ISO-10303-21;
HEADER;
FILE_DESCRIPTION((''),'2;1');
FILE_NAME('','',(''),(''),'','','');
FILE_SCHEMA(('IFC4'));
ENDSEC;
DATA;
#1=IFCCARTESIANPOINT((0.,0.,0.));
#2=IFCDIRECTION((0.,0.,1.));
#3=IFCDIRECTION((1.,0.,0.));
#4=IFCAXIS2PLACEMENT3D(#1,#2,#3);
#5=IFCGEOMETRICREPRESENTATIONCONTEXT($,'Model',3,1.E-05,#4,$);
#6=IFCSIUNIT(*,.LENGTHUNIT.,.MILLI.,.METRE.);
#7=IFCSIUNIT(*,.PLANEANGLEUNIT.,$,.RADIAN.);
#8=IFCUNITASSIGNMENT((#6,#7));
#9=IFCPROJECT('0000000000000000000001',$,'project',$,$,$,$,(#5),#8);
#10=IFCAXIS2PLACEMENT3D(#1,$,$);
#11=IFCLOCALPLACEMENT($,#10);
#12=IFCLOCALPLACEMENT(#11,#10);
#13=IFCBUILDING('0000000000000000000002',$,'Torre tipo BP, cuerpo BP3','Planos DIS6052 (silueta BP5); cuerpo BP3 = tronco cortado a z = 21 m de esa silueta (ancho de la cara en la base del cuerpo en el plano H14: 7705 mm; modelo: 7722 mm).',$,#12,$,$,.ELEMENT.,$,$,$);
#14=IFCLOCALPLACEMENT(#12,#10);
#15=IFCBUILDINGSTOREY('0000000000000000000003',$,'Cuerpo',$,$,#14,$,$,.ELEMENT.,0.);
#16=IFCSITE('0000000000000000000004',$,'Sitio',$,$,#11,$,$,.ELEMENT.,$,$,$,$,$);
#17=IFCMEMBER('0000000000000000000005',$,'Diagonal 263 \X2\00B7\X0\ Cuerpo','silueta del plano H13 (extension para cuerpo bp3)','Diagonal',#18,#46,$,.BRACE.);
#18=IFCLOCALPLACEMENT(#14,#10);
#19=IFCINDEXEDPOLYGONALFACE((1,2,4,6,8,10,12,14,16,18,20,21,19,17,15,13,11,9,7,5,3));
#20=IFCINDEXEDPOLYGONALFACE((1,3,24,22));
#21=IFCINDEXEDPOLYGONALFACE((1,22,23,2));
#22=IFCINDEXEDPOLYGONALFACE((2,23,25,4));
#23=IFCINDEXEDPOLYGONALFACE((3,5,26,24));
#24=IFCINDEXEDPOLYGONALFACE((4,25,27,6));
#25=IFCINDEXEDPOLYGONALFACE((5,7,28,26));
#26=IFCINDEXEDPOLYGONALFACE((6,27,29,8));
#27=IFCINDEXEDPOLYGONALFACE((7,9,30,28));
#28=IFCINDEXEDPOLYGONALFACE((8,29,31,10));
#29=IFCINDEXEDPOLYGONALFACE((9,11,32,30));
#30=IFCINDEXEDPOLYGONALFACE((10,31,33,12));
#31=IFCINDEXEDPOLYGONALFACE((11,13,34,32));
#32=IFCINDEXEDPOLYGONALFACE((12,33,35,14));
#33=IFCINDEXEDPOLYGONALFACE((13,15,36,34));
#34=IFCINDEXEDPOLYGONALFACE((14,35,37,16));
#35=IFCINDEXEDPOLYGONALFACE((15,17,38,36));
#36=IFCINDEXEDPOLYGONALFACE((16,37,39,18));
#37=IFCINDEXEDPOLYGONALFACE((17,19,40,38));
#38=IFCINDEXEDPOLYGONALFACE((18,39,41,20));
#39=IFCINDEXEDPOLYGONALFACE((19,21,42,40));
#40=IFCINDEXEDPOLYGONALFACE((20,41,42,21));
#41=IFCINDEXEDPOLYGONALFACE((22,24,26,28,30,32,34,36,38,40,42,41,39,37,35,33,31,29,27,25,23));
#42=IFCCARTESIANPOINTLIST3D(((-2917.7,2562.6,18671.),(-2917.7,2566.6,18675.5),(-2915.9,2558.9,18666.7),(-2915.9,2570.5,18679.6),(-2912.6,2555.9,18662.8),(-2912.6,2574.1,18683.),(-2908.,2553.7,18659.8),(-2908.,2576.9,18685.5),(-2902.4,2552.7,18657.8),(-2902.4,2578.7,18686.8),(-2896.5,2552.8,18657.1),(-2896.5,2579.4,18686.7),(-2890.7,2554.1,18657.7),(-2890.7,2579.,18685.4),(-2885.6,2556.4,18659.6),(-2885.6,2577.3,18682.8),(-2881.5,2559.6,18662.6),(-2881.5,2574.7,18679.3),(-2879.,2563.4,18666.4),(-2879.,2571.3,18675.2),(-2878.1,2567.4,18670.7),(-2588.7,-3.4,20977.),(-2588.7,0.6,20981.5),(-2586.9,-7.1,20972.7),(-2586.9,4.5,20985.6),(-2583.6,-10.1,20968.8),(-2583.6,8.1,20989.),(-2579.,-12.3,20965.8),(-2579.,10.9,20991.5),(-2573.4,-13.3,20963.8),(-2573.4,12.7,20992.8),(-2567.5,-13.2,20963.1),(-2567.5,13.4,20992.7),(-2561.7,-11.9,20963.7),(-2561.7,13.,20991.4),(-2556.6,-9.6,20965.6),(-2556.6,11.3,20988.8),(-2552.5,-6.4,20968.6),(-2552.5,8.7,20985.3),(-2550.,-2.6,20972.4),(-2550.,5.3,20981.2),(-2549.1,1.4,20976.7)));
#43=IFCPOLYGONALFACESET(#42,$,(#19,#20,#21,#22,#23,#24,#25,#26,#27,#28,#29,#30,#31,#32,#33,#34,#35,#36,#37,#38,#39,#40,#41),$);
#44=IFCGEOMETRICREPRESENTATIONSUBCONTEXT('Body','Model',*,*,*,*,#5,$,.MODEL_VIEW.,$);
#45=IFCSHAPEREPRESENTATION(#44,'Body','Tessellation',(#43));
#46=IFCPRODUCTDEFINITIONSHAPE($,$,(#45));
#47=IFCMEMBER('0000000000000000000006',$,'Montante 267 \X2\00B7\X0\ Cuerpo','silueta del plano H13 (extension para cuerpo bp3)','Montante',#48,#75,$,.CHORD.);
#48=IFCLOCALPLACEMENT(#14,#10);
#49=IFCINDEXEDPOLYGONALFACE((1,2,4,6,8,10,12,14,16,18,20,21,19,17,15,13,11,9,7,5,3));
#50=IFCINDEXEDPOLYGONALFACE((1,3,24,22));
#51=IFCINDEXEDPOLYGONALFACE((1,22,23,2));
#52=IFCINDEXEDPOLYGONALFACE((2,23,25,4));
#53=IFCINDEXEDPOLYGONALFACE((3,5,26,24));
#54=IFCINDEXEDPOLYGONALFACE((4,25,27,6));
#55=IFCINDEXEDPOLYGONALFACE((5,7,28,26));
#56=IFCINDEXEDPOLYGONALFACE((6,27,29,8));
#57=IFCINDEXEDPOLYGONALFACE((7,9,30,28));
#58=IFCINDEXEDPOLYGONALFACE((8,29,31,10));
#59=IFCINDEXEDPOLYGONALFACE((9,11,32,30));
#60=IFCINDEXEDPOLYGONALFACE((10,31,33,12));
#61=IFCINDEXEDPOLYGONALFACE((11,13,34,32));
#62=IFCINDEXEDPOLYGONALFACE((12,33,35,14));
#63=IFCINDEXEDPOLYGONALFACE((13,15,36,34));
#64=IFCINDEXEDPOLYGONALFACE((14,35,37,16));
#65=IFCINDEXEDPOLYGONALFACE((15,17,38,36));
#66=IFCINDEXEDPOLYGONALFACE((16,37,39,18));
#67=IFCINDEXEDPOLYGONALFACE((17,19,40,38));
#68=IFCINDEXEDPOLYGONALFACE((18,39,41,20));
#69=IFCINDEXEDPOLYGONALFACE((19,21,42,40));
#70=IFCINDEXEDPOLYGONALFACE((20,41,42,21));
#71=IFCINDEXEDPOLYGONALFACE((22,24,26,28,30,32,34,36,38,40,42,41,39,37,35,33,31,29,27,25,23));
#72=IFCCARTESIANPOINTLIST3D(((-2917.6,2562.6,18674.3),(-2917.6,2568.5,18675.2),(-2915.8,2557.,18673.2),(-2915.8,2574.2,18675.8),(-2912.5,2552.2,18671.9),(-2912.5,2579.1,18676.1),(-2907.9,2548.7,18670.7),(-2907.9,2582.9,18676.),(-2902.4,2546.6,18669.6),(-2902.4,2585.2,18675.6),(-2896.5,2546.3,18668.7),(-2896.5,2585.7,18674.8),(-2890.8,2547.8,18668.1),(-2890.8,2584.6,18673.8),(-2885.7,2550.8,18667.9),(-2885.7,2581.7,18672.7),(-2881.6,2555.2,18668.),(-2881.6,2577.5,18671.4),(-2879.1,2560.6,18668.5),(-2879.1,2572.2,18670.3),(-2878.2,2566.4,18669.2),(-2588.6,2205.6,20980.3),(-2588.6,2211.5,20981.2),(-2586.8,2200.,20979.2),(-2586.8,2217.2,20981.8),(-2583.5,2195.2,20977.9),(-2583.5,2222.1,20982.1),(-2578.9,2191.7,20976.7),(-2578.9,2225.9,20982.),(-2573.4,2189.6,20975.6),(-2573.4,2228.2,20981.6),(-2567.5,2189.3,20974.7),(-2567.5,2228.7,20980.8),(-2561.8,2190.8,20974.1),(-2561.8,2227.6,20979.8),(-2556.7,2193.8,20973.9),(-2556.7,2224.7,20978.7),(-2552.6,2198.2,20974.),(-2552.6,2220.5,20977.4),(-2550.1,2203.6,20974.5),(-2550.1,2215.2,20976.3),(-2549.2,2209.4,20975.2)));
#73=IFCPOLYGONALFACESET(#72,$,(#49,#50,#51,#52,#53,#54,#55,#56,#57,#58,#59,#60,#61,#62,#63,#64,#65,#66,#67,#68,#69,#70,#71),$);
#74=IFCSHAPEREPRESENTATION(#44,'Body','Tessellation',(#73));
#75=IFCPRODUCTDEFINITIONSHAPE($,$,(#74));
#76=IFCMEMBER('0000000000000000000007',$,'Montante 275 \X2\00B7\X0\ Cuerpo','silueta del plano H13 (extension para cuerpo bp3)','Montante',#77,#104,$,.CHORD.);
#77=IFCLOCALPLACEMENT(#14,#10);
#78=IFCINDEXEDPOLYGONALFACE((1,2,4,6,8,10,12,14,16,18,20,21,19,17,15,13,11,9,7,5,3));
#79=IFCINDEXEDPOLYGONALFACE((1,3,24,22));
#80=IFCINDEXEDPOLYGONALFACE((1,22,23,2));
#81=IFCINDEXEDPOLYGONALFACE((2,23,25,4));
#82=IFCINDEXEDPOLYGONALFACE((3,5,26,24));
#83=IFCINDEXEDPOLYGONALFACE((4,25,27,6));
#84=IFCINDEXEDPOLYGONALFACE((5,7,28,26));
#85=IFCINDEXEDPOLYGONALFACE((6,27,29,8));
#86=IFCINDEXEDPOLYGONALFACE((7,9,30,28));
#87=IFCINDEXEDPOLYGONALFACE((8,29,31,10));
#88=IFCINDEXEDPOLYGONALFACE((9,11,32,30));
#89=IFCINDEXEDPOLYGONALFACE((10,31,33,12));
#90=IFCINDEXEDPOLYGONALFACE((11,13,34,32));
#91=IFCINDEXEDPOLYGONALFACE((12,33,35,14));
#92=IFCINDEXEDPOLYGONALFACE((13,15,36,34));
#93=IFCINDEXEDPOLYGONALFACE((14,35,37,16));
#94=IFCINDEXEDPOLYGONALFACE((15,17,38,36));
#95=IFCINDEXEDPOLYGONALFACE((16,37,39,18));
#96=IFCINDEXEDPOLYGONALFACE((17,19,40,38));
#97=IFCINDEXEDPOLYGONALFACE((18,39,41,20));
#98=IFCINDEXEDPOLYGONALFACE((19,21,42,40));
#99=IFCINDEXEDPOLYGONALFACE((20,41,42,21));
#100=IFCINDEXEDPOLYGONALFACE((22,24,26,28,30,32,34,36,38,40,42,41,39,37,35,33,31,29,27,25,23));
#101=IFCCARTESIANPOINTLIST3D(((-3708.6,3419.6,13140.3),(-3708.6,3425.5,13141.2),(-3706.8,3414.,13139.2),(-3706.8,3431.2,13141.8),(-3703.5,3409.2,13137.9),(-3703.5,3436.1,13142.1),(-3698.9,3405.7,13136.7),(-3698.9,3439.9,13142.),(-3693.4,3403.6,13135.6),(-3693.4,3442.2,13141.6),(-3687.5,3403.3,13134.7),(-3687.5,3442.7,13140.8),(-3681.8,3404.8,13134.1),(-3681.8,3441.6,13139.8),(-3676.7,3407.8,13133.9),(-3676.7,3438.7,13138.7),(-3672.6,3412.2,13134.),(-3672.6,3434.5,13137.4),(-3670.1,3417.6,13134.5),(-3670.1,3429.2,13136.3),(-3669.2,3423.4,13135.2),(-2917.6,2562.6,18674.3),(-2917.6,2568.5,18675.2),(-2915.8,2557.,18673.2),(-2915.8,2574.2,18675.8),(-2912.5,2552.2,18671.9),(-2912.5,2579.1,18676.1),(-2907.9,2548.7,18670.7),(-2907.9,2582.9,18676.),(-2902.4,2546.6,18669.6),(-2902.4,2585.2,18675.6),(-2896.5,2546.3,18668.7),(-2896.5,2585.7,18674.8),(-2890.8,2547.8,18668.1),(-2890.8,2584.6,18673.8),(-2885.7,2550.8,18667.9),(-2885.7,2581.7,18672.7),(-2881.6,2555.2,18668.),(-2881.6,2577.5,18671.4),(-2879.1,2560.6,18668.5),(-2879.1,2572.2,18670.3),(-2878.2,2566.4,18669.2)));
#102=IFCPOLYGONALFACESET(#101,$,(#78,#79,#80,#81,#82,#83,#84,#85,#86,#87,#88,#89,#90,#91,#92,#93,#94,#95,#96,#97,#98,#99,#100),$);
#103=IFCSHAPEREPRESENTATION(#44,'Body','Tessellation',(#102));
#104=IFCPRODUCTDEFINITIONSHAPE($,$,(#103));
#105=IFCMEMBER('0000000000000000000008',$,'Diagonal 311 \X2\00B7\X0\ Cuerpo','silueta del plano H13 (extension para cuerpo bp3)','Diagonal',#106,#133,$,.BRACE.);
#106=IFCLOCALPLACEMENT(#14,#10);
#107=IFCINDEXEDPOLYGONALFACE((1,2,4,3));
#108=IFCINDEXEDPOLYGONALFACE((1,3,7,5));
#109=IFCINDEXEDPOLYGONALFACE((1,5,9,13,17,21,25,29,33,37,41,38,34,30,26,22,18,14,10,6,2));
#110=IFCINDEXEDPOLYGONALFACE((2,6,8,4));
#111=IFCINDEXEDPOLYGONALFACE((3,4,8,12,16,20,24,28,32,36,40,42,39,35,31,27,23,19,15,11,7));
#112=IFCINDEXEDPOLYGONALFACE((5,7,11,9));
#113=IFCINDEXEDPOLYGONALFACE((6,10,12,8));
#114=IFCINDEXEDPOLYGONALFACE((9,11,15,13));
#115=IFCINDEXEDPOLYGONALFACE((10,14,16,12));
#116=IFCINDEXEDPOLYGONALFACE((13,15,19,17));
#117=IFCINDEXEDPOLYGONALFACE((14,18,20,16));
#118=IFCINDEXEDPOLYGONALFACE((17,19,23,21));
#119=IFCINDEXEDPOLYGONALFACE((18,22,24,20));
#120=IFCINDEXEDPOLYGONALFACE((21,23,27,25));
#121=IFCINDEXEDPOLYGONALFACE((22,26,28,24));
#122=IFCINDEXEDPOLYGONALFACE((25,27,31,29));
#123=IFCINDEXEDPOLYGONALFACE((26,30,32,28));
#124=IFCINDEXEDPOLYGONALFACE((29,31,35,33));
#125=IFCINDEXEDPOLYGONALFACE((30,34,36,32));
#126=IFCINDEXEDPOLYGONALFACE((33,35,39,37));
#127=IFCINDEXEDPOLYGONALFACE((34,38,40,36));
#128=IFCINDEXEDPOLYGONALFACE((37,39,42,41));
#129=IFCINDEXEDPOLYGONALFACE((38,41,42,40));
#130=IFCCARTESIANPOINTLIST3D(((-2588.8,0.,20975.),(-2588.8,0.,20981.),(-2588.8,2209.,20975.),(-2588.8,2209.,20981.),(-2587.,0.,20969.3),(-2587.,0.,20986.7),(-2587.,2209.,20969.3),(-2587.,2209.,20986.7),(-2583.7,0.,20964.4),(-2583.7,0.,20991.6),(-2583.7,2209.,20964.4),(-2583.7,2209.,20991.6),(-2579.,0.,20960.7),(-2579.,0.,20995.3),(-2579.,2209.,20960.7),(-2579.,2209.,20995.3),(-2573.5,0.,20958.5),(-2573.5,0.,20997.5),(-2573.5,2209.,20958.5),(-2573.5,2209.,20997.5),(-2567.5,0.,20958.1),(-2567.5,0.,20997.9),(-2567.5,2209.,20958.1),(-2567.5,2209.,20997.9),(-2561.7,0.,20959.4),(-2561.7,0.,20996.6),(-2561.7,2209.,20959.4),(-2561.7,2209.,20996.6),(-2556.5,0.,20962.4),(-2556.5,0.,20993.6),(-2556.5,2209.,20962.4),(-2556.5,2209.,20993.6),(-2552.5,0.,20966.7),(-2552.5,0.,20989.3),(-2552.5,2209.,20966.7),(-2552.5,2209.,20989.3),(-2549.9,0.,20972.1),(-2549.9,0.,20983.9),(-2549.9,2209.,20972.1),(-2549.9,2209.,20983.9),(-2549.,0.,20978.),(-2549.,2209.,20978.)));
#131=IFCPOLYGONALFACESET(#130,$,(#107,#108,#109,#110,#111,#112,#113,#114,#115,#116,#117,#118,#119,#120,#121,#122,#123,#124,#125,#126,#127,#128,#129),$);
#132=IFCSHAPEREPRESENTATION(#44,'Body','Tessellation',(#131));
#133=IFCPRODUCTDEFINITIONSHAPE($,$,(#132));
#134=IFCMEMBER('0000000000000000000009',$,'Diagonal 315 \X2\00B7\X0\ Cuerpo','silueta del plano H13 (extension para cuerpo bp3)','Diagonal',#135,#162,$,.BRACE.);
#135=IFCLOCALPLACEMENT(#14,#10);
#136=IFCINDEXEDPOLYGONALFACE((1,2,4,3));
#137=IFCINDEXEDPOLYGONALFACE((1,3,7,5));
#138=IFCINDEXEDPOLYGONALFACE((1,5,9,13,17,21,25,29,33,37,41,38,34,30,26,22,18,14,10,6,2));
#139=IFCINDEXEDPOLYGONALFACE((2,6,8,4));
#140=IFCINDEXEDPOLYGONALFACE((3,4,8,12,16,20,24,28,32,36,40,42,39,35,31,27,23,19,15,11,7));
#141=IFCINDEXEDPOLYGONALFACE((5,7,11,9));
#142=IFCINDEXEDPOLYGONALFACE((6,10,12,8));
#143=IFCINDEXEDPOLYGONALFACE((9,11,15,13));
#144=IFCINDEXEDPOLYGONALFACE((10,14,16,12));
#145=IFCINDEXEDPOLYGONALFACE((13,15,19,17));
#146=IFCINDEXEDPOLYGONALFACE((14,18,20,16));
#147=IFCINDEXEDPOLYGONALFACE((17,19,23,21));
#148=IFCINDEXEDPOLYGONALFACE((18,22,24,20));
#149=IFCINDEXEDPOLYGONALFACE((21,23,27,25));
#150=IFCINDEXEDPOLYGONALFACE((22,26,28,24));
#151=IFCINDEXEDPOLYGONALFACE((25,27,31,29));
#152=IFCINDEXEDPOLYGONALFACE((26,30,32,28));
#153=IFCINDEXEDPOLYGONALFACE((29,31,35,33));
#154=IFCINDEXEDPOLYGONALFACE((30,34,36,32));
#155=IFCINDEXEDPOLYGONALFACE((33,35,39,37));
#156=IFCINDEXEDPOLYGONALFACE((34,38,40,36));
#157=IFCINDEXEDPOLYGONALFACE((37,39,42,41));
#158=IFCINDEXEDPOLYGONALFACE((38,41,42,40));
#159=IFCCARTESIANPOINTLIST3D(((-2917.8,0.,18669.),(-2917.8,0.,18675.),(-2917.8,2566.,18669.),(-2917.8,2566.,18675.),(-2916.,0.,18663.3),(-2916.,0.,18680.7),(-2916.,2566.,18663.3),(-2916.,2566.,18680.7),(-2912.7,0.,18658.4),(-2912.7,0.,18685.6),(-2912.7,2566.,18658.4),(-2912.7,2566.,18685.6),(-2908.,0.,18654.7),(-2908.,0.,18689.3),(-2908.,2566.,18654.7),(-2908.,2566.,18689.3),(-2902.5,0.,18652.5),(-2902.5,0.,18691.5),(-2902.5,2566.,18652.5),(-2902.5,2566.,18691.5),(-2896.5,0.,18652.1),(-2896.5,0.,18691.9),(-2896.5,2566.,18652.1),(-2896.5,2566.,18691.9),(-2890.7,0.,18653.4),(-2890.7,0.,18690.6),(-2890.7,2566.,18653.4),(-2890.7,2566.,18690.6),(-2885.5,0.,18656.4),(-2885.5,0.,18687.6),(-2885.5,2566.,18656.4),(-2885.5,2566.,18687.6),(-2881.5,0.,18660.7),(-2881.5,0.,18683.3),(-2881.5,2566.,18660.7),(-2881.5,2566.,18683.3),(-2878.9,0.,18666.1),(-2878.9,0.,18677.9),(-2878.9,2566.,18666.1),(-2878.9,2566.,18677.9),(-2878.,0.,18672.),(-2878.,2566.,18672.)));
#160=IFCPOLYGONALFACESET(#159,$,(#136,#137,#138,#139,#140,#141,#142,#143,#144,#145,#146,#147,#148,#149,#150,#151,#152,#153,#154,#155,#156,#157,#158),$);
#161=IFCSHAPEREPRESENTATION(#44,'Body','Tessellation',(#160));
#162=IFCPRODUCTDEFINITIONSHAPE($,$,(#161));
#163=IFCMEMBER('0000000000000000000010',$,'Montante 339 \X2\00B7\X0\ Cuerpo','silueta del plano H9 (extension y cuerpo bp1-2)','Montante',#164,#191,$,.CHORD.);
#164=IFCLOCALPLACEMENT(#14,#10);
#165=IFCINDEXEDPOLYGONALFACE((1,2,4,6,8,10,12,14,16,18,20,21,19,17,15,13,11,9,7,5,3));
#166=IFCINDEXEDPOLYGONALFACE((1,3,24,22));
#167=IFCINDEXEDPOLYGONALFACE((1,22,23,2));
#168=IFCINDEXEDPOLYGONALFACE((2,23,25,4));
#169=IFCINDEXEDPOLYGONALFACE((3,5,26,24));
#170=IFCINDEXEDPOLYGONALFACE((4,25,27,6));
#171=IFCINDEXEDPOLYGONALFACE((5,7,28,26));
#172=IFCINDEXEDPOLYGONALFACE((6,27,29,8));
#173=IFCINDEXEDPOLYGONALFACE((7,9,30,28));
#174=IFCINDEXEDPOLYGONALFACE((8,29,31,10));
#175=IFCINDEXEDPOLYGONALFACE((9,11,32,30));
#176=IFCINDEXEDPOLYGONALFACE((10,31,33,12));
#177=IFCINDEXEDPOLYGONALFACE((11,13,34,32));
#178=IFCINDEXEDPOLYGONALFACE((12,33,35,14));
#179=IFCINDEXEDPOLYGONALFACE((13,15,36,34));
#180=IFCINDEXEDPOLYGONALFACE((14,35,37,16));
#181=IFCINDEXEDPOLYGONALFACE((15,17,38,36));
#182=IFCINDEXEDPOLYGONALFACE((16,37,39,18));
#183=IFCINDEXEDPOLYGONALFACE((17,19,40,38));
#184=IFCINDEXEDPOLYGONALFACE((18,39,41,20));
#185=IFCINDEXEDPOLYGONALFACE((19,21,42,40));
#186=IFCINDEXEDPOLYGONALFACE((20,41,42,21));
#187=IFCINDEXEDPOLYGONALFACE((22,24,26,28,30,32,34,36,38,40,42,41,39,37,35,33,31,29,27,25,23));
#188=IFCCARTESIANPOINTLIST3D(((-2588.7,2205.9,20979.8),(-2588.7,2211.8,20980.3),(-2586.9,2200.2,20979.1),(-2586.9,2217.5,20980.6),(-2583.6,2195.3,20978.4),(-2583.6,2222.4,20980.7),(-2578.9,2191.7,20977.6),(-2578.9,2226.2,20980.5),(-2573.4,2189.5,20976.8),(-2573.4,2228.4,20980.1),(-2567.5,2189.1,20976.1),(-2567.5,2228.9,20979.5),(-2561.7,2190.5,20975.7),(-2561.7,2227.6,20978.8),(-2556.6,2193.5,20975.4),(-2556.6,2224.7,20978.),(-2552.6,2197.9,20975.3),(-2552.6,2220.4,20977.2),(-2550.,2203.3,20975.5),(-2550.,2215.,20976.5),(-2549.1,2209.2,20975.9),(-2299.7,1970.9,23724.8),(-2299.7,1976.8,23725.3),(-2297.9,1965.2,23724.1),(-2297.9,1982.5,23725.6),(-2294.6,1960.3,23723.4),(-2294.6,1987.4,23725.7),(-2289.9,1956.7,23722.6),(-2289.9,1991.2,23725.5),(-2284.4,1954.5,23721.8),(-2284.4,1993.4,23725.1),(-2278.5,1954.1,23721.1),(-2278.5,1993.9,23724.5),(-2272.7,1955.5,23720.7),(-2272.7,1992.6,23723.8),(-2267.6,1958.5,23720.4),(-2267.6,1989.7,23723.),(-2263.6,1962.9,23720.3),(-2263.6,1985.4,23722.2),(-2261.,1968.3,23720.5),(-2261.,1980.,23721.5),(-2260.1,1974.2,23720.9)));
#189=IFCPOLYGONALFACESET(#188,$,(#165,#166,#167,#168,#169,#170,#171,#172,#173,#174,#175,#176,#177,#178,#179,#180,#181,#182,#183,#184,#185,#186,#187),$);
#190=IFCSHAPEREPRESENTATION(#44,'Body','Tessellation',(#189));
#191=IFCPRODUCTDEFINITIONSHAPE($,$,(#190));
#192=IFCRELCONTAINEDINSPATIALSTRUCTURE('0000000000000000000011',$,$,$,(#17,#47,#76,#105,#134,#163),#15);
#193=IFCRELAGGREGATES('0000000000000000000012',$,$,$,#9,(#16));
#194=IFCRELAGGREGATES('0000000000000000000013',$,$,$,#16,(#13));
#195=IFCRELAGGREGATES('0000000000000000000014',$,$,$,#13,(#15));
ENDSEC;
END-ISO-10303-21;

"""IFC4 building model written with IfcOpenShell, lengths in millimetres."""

from ifc_helpers import new_model, si_unit, frame, origin, origin_with_axes, place, context, subcontext, project, spatial, circle, extrude, element, save


model = new_model("IFC4")

# Units and contexts
model_context = context("Model", 3, precision=1e-05, world=origin_with_axes())
body_context = subcontext(model_context, "Body", "Model", "MODEL_VIEW")
ifc_project = project(units=[si_unit("LENGTHUNIT", "METRE", prefix="MILLI"), si_unit("PLANEANGLEUNIT", "RADIAN")], contexts=[model_context])

# Site, building, storey
site_placement = place(None, origin())
site = spatial("IfcSite", under=ifc_project, at=site_placement, Name="Sitio", CompositionType="ELEMENT")
building_placement = place(site_placement, origin())
building = spatial("IfcBuilding", under=site, at=building_placement, Name="Torre tipo BP, cuerpo BP3", Description="Planos DIS6052 (silueta BP5); cuerpo BP3 = tronco cortado a z = 21 m de esa silueta (ancho de la cara en la base del cuerpo en el plano H14: 7705 mm; modelo: 7722 mm).", CompositionType="ELEMENT")
storey_placement = place(building_placement, origin())
storey = spatial("IfcBuildingStorey", under=building, at=storey_placement, Name="Cuerpo", CompositionType="ELEMENT", Elevation=0.0)

# Members
for number, where, z_axis, x_axis, name in (
    (1, (-2569.0, 0.0, 20978.0), (-0.094934, 0.740425, -0.665401), (0.995484, 0.07061, -0.063456), "Diagonal 263 · Cuerpo"),
):
    element("IfcMember", number, at=place(storey_placement, frame(where, z_axis=z_axis, x_axis=x_axis)), inside=storey, Name=name, Description="silueta del plano H13 (extension para cuerpo bp3)", ObjectType="Diagonal", PredefinedType="BRACE", context=body_context, shape_type="SweptSolid", body=[
        extrude(circle(Radius=20.0), None, (0.0, 0.0, 1.0), 3465.6),
    ])
member_1_placement = place(storey_placement, frame((-2569.0, 2209.0, 20978.0), z_axis=(-0.139611, 0.151493, -0.978549), x_axis=(0.990206, 0.021359, -0.137967)))
element("IfcMember", 2, at=member_1_placement, inside=storey, Name="Montante 267 · Cuerpo", Description="silueta del plano H13 (extension para cuerpo bp3)", ObjectType="Montante", PredefinedType="CHORD", context=body_context, shape_type="SweptSolid", body=[
    extrude(circle(Radius=20.0), None, (0.0, 0.0, 1.0), 2356.5),
])
member_2_placement = place(storey_placement, frame((-2898.0, 2566.0, 18672.0), z_axis=(-0.139863, 0.151532, -0.978507), x_axis=(0.990171, 0.021404, -0.138215)))
element("IfcMember", 3, at=member_2_placement, inside=storey, Name="Montante 275 · Cuerpo", Description="silueta del plano H13 (extension para cuerpo bp3)", ObjectType="Montante", PredefinedType="CHORD", context=body_context, shape_type="SweptSolid", body=[
    extrude(circle(Radius=20.0), None, (0.0, 0.0, 1.0), 5655.6),
])
member_3_placement = place(storey_placement, frame((-2569.0, 2209.0, 20978.0), z_axis=(0.0, -1.0, 0.0), x_axis=(1.0, 0.0, 0.0)))
element("IfcMember", 4, at=member_3_placement, inside=storey, Name="Diagonal 311 · Cuerpo", Description="silueta del plano H13 (extension para cuerpo bp3)", ObjectType="Diagonal", PredefinedType="BRACE", context=body_context, shape_type="SweptSolid", body=[
    extrude(circle(Radius=20.0), None, (0.0, 0.0, 1.0), 2209.0),
])
member_4_placement = place(storey_placement, frame((-2898.0, 2566.0, 18672.0), z_axis=(0.0, -1.0, 0.0), x_axis=(1.0, 0.0, 0.0)))
element("IfcMember", 5, at=member_4_placement, inside=storey, Name="Diagonal 315 · Cuerpo", Description="silueta del plano H13 (extension para cuerpo bp3)", ObjectType="Diagonal", PredefinedType="BRACE", context=body_context, shape_type="SweptSolid", body=[
    extrude(circle(Radius=20.0), None, (0.0, 0.0, 1.0), 2566.0),
])
member_5_placement = place(storey_placement, frame((-2280.0, 1974.0, 23723.0), z_axis=(-0.104326, 0.084833, -0.990918), x_axis=(0.994543, 0.008899, -0.103946)))
element("IfcMember", 6, at=member_5_placement, inside=storey, Name="Montante 339 · Cuerpo", Description="silueta del plano H9 (extension y cuerpo bp1-2)", ObjectType="Montante", PredefinedType="CHORD", context=body_context, shape_type="SweptSolid", body=[
    extrude(circle(Radius=20.0), None, (0.0, 0.0, 1.0), 2770.2),
])

save(model, "model.ifc")
